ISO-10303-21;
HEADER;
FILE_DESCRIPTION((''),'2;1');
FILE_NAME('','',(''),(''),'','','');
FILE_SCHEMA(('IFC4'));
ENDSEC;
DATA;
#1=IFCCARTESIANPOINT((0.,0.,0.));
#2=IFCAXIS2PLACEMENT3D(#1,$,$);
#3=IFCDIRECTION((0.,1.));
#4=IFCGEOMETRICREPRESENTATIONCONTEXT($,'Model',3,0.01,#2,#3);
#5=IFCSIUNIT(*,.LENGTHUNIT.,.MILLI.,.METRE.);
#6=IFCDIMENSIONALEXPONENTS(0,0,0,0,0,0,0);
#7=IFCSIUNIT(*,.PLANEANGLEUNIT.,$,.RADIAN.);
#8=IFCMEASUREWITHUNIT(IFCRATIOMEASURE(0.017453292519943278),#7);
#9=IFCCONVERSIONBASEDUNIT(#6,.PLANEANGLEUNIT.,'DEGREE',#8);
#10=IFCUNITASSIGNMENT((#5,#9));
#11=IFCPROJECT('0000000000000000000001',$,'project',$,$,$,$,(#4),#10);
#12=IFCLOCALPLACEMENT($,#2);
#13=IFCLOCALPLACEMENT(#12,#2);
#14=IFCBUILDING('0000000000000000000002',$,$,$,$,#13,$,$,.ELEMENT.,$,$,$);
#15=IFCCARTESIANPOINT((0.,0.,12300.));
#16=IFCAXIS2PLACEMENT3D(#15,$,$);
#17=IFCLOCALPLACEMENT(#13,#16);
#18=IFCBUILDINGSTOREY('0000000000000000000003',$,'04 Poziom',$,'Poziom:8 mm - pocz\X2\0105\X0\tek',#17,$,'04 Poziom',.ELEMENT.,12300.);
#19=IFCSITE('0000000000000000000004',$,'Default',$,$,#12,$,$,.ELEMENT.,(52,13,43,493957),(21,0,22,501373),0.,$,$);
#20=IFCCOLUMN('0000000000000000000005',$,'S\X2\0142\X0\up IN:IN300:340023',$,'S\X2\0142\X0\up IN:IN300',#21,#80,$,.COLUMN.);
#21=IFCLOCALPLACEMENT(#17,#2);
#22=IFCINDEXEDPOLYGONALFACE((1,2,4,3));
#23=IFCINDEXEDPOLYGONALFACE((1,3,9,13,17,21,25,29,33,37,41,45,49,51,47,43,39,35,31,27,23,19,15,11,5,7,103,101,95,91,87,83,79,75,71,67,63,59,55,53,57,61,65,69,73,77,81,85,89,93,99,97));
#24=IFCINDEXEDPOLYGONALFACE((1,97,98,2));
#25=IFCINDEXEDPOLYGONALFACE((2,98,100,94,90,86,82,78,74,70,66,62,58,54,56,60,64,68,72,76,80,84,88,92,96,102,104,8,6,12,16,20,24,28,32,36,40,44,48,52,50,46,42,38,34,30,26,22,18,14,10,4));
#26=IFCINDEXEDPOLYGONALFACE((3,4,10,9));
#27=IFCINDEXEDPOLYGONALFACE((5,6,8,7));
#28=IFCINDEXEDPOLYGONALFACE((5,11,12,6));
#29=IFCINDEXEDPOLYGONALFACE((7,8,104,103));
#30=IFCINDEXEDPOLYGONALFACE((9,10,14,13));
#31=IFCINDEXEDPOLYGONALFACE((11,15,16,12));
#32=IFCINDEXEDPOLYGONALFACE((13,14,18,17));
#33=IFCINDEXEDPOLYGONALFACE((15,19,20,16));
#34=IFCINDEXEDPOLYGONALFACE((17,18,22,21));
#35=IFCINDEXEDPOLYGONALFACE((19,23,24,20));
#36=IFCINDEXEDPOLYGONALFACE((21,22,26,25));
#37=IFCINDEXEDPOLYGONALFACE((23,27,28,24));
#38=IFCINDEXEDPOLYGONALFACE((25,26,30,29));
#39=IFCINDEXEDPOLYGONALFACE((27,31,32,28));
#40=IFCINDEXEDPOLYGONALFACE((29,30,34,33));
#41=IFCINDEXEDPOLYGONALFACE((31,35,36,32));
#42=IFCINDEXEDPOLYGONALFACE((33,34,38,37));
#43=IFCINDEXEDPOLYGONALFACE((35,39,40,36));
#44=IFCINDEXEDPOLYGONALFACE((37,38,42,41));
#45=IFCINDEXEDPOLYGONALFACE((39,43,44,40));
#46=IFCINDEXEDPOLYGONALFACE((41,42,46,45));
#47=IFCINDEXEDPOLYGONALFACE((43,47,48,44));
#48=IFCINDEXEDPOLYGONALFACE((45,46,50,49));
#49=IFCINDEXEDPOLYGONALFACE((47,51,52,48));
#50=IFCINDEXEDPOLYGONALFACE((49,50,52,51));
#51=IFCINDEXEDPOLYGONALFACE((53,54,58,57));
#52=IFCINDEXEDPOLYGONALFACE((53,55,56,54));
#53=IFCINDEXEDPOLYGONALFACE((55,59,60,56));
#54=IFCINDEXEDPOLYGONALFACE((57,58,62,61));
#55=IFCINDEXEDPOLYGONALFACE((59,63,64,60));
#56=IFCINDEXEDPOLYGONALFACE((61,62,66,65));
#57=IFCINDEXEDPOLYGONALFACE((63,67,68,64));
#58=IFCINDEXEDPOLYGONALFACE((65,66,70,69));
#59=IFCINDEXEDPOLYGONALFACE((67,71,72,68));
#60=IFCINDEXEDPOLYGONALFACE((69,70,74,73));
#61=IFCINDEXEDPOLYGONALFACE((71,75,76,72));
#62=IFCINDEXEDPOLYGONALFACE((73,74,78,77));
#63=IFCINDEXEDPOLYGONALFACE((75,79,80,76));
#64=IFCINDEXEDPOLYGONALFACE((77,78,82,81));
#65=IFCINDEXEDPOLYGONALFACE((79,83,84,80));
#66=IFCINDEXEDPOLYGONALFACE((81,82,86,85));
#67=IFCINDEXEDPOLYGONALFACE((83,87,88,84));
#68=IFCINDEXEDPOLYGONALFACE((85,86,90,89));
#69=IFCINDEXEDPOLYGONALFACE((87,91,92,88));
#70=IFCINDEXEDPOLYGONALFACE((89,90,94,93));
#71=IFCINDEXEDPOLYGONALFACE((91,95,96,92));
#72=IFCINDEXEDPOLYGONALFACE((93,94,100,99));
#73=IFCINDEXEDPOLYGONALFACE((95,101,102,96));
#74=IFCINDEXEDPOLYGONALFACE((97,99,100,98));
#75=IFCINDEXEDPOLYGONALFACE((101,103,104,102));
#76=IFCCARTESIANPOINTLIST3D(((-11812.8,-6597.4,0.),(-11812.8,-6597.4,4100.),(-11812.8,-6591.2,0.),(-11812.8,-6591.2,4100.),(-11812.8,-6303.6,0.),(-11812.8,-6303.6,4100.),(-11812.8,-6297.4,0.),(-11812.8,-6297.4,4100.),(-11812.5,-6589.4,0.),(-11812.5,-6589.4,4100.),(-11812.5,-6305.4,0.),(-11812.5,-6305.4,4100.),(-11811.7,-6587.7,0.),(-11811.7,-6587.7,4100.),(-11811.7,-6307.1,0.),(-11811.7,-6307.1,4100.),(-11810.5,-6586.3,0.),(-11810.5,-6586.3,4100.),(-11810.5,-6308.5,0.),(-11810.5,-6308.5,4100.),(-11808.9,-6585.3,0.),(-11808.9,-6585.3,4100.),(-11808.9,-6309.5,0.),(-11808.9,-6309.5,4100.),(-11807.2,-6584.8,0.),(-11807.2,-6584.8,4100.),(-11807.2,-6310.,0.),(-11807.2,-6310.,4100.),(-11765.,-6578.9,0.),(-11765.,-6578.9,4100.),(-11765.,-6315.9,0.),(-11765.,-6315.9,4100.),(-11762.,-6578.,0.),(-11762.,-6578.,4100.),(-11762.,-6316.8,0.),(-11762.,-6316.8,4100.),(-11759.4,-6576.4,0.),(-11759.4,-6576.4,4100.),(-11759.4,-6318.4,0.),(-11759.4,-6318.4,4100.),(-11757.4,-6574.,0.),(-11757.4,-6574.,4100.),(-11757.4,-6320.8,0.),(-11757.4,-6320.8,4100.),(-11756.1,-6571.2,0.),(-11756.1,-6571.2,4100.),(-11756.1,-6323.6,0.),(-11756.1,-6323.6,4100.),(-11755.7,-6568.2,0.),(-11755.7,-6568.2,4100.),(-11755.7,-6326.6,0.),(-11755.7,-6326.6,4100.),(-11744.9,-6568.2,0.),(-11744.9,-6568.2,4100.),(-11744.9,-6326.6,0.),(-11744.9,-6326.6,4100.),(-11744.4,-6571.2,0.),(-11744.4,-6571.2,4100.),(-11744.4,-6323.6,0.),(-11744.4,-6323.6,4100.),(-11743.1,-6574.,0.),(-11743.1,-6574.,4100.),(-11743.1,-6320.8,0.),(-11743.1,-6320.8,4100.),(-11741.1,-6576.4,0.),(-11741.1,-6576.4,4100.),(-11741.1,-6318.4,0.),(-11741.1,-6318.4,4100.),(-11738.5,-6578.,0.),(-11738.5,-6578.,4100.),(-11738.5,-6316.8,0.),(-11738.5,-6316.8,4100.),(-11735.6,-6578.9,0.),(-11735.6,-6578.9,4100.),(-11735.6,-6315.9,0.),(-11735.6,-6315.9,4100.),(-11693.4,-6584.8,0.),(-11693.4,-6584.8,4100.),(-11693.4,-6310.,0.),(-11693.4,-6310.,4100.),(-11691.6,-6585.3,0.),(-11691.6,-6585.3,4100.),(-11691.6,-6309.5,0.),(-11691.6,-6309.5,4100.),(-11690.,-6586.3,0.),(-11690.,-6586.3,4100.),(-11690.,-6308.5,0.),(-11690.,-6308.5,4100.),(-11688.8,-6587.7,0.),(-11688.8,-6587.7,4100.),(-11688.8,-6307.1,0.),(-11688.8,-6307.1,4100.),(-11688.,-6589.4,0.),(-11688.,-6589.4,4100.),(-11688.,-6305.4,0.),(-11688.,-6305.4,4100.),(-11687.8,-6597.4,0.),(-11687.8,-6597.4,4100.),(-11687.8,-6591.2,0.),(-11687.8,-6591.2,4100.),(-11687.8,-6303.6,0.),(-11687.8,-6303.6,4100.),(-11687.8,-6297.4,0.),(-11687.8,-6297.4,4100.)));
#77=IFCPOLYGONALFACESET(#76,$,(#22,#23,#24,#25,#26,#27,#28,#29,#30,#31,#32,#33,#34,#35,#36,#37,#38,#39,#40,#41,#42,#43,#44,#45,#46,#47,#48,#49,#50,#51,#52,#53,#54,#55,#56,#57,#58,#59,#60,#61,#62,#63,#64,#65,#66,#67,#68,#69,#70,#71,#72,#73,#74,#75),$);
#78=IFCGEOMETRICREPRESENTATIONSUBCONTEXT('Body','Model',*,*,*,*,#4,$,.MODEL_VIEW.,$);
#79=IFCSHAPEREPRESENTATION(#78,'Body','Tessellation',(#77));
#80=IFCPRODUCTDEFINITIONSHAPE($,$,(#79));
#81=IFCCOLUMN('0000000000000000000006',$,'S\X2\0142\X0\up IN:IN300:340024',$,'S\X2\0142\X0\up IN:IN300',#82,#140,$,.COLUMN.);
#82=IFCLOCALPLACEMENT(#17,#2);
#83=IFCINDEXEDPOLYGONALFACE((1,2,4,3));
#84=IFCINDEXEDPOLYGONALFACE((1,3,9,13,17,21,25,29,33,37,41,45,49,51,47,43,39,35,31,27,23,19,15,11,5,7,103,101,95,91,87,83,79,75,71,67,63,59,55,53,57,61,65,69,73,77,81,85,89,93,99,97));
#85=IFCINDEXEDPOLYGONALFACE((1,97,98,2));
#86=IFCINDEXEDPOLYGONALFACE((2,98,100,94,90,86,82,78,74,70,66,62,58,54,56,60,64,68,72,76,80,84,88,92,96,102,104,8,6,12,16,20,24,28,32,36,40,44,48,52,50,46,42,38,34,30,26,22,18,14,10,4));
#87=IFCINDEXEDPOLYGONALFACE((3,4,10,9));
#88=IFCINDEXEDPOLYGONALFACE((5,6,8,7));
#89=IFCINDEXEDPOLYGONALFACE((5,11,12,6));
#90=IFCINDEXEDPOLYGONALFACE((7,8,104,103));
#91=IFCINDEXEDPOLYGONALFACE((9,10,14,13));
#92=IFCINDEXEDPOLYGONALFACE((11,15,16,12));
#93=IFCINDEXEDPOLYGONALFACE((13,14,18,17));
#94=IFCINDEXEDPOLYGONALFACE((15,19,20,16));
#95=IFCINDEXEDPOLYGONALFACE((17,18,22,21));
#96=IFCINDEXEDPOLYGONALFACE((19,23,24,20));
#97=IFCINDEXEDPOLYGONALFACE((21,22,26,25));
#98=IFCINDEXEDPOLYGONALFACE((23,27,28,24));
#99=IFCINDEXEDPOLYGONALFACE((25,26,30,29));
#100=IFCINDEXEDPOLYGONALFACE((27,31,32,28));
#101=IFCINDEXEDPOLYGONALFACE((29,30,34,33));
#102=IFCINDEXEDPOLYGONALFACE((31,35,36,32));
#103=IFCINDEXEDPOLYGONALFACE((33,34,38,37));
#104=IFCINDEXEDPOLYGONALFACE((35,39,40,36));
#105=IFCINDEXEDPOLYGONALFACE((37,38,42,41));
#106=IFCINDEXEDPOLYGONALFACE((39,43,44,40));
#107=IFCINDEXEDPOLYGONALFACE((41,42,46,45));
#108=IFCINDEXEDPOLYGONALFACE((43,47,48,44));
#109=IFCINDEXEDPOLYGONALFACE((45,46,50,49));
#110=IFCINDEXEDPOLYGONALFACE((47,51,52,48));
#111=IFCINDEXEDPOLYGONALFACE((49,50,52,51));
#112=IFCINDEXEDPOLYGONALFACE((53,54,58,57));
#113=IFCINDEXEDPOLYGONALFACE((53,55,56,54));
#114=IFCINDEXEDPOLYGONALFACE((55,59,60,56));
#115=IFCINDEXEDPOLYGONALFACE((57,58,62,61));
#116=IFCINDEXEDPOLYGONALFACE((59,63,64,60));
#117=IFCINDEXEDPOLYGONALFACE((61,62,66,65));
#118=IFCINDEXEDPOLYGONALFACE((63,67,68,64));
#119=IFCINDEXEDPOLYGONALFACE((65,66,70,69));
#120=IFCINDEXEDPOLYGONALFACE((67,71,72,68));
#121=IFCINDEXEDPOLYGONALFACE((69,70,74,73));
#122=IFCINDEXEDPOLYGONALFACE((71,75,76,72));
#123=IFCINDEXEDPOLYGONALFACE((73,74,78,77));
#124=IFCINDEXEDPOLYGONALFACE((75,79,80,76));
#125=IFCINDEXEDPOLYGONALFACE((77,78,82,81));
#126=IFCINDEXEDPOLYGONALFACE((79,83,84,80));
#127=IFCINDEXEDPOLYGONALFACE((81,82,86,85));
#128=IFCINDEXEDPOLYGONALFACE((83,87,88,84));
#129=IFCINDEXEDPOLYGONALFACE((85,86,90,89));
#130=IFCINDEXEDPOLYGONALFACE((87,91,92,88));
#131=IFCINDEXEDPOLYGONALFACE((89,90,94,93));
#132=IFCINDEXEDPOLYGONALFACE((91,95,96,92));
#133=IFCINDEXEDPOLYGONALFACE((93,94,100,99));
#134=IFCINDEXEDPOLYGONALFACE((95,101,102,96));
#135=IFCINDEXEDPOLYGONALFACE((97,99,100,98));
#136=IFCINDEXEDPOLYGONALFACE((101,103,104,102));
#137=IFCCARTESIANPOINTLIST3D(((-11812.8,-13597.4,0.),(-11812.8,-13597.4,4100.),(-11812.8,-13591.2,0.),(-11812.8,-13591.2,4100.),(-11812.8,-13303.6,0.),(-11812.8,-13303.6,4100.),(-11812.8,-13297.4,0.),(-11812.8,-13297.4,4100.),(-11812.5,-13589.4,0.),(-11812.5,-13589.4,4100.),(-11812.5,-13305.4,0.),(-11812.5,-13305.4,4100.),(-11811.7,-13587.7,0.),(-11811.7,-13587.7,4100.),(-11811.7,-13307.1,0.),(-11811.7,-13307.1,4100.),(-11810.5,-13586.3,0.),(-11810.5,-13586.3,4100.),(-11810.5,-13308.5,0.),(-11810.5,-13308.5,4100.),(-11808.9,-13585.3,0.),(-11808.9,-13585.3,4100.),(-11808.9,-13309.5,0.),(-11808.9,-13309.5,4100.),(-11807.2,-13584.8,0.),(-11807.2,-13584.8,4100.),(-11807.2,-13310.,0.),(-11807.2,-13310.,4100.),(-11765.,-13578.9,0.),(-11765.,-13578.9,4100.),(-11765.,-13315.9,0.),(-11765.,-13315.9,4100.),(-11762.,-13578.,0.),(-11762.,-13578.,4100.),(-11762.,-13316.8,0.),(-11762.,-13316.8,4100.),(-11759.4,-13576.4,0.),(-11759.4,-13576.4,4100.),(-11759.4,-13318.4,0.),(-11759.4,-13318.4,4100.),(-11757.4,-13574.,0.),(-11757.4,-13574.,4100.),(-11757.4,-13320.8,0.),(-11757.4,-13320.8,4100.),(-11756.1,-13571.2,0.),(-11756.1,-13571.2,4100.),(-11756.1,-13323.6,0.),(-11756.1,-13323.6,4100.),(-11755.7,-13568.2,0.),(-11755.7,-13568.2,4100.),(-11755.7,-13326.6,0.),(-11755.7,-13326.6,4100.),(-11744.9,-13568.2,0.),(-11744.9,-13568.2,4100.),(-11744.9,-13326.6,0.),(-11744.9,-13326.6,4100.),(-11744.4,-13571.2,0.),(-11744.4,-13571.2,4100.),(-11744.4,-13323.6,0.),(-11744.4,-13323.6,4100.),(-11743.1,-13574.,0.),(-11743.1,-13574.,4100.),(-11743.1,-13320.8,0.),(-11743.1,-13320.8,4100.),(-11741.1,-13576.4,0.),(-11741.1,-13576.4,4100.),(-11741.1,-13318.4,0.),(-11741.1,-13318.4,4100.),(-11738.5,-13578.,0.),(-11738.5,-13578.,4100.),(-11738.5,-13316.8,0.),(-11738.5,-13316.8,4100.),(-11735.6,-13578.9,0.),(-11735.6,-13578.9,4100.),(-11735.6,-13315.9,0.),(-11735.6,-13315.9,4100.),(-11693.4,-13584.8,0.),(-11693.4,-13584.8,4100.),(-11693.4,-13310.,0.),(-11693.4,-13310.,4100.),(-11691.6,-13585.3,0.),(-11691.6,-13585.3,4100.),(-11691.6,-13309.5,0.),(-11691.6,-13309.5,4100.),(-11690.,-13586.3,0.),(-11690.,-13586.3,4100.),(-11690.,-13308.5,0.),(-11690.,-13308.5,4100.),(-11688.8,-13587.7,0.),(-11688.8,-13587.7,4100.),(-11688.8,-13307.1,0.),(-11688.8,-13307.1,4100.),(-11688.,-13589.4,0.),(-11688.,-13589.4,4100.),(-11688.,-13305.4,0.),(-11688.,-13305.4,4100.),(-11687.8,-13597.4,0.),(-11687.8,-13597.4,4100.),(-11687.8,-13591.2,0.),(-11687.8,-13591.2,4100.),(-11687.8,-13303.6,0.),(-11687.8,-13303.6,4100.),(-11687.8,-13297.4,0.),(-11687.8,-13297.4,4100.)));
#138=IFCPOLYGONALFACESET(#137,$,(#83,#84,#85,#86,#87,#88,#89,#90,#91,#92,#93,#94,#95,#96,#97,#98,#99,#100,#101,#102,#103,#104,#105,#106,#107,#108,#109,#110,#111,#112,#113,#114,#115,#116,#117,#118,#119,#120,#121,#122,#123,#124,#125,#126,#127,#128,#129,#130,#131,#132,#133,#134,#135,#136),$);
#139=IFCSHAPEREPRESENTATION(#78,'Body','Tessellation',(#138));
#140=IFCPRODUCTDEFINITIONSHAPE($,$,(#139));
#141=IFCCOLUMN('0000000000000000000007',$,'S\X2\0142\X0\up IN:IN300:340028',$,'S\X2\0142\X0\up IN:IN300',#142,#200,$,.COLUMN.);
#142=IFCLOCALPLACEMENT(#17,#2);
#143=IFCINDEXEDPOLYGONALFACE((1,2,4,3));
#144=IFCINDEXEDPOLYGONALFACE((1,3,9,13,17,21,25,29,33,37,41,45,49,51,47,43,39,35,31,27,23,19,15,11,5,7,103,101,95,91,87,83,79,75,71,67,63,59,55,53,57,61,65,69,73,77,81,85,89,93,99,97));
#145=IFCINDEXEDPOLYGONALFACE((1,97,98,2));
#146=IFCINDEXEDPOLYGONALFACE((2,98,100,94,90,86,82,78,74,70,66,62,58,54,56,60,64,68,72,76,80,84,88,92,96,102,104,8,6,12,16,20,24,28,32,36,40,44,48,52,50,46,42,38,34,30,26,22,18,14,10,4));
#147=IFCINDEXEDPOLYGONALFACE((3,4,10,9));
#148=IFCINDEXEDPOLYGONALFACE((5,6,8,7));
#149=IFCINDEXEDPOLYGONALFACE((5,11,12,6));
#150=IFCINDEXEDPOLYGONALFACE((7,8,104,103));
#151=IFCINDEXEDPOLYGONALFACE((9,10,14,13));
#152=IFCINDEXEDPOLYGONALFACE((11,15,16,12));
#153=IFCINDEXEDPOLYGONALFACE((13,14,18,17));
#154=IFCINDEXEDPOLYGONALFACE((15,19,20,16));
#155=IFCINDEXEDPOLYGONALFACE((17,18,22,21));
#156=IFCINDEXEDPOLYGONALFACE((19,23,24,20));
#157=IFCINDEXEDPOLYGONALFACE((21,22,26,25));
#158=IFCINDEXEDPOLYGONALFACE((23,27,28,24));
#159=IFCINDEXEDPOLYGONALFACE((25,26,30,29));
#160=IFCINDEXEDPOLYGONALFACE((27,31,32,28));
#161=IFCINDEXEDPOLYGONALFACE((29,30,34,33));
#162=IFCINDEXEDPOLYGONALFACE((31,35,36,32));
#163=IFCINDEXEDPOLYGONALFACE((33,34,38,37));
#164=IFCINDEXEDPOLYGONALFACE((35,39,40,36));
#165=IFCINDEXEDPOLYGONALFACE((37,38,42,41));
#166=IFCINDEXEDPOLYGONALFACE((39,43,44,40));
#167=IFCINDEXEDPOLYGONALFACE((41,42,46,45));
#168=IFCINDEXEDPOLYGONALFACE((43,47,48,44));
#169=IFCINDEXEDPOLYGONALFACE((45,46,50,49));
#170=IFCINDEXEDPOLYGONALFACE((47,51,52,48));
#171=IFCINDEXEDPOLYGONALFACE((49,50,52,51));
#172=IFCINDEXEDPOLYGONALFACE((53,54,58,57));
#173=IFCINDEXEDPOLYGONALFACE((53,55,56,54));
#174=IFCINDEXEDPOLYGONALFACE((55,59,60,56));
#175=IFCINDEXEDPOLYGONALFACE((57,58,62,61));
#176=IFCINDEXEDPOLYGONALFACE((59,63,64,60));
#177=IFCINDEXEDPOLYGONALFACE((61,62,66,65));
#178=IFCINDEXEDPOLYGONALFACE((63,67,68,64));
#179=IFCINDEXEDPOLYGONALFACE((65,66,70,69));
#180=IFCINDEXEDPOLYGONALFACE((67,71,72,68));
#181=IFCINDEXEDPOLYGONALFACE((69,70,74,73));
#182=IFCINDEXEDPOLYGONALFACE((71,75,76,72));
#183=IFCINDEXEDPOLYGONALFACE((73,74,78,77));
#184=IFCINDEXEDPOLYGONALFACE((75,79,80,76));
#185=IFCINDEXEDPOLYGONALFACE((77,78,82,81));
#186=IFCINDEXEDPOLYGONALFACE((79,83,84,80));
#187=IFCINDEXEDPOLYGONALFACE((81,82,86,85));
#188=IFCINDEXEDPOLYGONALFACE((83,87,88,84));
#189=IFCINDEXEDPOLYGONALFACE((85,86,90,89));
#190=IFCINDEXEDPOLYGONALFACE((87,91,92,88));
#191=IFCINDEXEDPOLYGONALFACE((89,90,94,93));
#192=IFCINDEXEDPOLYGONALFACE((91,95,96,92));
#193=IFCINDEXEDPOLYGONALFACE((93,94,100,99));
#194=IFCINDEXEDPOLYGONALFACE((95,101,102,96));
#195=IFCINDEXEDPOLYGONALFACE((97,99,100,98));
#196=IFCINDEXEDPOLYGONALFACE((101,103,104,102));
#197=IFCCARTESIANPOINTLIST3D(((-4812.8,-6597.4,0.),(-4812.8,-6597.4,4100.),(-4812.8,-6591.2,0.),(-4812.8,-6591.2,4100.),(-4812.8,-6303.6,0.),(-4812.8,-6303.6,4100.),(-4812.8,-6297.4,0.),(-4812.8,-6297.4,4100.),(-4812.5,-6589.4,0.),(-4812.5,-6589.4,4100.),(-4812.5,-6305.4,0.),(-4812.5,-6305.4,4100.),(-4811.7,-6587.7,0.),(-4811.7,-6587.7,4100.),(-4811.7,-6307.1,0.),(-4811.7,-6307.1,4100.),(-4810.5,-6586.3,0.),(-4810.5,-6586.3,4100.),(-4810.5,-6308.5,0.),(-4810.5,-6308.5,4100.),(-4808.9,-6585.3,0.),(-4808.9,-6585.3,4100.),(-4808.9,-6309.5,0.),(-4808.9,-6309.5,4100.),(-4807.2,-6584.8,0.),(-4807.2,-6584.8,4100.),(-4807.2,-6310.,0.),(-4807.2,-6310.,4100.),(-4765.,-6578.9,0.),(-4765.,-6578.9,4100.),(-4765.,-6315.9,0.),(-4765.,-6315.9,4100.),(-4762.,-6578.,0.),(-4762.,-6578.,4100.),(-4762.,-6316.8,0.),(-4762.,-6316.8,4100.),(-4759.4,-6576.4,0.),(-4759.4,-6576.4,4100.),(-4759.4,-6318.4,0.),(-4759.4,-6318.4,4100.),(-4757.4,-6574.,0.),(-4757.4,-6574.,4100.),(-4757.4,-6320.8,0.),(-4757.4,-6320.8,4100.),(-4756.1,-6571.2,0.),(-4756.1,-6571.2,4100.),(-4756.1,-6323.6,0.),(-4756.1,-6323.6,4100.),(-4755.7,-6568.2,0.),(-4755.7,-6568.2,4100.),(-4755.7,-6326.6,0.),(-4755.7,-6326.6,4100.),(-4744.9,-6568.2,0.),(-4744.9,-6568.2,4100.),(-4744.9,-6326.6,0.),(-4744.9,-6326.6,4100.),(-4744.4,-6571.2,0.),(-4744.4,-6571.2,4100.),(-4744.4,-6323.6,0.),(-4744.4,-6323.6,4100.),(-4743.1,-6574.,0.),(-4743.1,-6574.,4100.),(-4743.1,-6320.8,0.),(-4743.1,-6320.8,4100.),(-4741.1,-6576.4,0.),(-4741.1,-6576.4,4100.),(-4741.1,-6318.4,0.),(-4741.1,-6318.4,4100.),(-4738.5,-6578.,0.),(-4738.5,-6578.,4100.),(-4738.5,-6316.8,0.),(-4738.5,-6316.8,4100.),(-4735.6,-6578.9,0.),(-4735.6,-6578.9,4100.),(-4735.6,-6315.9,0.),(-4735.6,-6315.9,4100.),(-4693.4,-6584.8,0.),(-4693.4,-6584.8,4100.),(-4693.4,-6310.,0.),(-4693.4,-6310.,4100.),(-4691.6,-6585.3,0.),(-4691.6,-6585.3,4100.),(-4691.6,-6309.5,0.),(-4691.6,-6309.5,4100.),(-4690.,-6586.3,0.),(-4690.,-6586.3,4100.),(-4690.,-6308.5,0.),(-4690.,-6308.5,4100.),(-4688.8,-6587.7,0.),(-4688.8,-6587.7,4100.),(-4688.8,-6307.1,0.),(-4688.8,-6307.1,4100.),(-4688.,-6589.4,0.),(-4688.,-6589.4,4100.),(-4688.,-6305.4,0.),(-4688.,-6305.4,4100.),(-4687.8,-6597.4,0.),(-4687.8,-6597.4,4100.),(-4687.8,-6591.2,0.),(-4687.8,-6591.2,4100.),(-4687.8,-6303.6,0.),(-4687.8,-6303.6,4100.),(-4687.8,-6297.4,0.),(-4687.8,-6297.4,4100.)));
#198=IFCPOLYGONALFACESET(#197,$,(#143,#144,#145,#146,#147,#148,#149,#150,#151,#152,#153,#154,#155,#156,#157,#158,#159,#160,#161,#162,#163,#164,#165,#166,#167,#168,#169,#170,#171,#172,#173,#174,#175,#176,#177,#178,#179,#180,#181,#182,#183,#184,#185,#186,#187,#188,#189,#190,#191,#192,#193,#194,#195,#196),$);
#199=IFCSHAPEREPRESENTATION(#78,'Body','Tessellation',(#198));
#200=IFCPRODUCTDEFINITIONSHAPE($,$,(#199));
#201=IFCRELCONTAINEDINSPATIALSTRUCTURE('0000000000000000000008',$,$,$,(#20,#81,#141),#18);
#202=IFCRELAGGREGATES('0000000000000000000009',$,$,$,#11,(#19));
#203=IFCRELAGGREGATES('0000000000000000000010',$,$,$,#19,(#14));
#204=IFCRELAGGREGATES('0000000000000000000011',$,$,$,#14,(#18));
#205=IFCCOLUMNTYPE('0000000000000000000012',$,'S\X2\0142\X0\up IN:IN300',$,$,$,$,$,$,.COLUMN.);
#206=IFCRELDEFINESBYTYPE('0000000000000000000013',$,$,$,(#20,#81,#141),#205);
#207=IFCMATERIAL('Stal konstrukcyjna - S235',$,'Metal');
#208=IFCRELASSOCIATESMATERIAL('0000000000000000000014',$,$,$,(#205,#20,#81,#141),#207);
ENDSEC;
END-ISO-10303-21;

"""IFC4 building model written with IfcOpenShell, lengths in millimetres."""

from ifc_helpers import new_model, entity, si_unit, converted_unit, direction, frame, origin, place, context, subcontext, project, spatial, line, arc, indexed_curve, outline, extrude, source, transform, mapped, material, type_object, type_shapes, element, save


model = new_model("IFC4")

# Units and contexts
model_context = context("Model", 3, precision=0.01, world=origin(), true_north=direction((0.0, 1.0)))
body_context = subcontext(model_context, "Body", "Model", "MODEL_VIEW")
ifc_project = project(units=[si_unit("LENGTHUNIT", "METRE", prefix="MILLI"), converted_unit("PLANEANGLEUNIT", "DEGREE", entity("IfcRatioMeasure", 0.017453292519943278), si_unit("PLANEANGLEUNIT", "RADIAN"), dimensions=[0, 0, 0, 0, 0, 0, 0])], contexts=[model_context])

# Site, building, storey
site_placement = place(None, origin())
site = spatial("IfcSite", under=ifc_project, at=site_placement, Name="Default", CompositionType="ELEMENT", RefLatitude=(52, 13, 43, 493957), RefLongitude=(21, 0, 22, 501373), RefElevation=0.0)
building_placement = place(site_placement, origin())
building = spatial("IfcBuilding", under=site, at=building_placement, CompositionType="ELEMENT")
storey_placement = place(building_placement, frame((0.0, 0.0, 12300.0)))
storey = spatial("IfcBuildingStorey", under=building, at=storey_placement, Name="04 Poziom", ObjectType="Poziom:8 mm - początek", LongName="04 Poziom", CompositionType="ELEMENT", Elevation=12300.0)

# Columns
ifc_material = material(Name="Stal konstrukcyjna - S235", Category="Metal")
column_type = type_object("IfcColumnType", Name="Słup IN:IN300", PredefinedType="COLUMN", material=ifc_material)
shared_shape_1 = source(origin(), body_context, "Body", "SweptSolid", [
    extrude(outline(indexed_curve([(143.8, -62.5), (150.0, -62.5), (150.0, 62.5), (143.8, 62.5), (139.6, 60.9), (137.4, 56.9), (131.5, 14.7), (127.9, 8.1), (120.8, 5.4), (-120.8, 5.4), (-127.9, 8.1), (-131.5, 14.7), (-137.4, 56.9), (-139.6, 60.9), (-143.8, 62.5), (-150.0, 62.5), (-150.0, -62.5), (-143.8, -62.5), (-139.6, -60.9), (-137.4, -56.9), (-131.5, -14.7), (-127.9, -8.1), (-120.8, -5.4), (120.8, -5.4), (127.9, -8.1), (131.5, -14.7), (137.4, -56.9), (139.6, -60.9)], segments=[line(1, 2, 3, 4), arc(4, 5, 6), line(6, 7), arc(7, 8, 9), line(9, 10), arc(10, 11, 12), line(12, 13), arc(13, 14, 15), line(15, 16, 17, 18), arc(18, 19, 20), line(20, 21), arc(21, 22, 23), line(23, 24), arc(24, 25, 26), line(26, 27), arc(27, 28, 1)], self_intersect=False)), frame((0.0, 0.0, 12300.0), z_axis=(0.0, 0.0, 1.0), x_axis=(0.0, -1.0, 0.0)), (0.0, 0.0, 1.0), 4100.0),
])
type_shapes(column_type, [shared_shape_1])
for number, where, name in (
    (1, (-11750.3, -6447.4, -12300.0), "Słup IN:IN300:340023"),
    (2, (-11750.3, -13447.4, -12300.0), "Słup IN:IN300:340024"),
    (3, (-4750.3, -6447.4, -12300.0), "Słup IN:IN300:340028"),
):
    element("IfcColumn", number, at=place(storey_placement, frame(where)), inside=storey, type_object=column_type, material=ifc_material, Name=name, ObjectType="Słup IN:IN300", PredefinedType="COLUMN", context=body_context, shape_type="MappedRepresentation", body=[
        mapped(shared_shape_1, transform((0.0, 0.0, 0.0), scale=1.0)),
    ])

save(model, "model.ifc")
